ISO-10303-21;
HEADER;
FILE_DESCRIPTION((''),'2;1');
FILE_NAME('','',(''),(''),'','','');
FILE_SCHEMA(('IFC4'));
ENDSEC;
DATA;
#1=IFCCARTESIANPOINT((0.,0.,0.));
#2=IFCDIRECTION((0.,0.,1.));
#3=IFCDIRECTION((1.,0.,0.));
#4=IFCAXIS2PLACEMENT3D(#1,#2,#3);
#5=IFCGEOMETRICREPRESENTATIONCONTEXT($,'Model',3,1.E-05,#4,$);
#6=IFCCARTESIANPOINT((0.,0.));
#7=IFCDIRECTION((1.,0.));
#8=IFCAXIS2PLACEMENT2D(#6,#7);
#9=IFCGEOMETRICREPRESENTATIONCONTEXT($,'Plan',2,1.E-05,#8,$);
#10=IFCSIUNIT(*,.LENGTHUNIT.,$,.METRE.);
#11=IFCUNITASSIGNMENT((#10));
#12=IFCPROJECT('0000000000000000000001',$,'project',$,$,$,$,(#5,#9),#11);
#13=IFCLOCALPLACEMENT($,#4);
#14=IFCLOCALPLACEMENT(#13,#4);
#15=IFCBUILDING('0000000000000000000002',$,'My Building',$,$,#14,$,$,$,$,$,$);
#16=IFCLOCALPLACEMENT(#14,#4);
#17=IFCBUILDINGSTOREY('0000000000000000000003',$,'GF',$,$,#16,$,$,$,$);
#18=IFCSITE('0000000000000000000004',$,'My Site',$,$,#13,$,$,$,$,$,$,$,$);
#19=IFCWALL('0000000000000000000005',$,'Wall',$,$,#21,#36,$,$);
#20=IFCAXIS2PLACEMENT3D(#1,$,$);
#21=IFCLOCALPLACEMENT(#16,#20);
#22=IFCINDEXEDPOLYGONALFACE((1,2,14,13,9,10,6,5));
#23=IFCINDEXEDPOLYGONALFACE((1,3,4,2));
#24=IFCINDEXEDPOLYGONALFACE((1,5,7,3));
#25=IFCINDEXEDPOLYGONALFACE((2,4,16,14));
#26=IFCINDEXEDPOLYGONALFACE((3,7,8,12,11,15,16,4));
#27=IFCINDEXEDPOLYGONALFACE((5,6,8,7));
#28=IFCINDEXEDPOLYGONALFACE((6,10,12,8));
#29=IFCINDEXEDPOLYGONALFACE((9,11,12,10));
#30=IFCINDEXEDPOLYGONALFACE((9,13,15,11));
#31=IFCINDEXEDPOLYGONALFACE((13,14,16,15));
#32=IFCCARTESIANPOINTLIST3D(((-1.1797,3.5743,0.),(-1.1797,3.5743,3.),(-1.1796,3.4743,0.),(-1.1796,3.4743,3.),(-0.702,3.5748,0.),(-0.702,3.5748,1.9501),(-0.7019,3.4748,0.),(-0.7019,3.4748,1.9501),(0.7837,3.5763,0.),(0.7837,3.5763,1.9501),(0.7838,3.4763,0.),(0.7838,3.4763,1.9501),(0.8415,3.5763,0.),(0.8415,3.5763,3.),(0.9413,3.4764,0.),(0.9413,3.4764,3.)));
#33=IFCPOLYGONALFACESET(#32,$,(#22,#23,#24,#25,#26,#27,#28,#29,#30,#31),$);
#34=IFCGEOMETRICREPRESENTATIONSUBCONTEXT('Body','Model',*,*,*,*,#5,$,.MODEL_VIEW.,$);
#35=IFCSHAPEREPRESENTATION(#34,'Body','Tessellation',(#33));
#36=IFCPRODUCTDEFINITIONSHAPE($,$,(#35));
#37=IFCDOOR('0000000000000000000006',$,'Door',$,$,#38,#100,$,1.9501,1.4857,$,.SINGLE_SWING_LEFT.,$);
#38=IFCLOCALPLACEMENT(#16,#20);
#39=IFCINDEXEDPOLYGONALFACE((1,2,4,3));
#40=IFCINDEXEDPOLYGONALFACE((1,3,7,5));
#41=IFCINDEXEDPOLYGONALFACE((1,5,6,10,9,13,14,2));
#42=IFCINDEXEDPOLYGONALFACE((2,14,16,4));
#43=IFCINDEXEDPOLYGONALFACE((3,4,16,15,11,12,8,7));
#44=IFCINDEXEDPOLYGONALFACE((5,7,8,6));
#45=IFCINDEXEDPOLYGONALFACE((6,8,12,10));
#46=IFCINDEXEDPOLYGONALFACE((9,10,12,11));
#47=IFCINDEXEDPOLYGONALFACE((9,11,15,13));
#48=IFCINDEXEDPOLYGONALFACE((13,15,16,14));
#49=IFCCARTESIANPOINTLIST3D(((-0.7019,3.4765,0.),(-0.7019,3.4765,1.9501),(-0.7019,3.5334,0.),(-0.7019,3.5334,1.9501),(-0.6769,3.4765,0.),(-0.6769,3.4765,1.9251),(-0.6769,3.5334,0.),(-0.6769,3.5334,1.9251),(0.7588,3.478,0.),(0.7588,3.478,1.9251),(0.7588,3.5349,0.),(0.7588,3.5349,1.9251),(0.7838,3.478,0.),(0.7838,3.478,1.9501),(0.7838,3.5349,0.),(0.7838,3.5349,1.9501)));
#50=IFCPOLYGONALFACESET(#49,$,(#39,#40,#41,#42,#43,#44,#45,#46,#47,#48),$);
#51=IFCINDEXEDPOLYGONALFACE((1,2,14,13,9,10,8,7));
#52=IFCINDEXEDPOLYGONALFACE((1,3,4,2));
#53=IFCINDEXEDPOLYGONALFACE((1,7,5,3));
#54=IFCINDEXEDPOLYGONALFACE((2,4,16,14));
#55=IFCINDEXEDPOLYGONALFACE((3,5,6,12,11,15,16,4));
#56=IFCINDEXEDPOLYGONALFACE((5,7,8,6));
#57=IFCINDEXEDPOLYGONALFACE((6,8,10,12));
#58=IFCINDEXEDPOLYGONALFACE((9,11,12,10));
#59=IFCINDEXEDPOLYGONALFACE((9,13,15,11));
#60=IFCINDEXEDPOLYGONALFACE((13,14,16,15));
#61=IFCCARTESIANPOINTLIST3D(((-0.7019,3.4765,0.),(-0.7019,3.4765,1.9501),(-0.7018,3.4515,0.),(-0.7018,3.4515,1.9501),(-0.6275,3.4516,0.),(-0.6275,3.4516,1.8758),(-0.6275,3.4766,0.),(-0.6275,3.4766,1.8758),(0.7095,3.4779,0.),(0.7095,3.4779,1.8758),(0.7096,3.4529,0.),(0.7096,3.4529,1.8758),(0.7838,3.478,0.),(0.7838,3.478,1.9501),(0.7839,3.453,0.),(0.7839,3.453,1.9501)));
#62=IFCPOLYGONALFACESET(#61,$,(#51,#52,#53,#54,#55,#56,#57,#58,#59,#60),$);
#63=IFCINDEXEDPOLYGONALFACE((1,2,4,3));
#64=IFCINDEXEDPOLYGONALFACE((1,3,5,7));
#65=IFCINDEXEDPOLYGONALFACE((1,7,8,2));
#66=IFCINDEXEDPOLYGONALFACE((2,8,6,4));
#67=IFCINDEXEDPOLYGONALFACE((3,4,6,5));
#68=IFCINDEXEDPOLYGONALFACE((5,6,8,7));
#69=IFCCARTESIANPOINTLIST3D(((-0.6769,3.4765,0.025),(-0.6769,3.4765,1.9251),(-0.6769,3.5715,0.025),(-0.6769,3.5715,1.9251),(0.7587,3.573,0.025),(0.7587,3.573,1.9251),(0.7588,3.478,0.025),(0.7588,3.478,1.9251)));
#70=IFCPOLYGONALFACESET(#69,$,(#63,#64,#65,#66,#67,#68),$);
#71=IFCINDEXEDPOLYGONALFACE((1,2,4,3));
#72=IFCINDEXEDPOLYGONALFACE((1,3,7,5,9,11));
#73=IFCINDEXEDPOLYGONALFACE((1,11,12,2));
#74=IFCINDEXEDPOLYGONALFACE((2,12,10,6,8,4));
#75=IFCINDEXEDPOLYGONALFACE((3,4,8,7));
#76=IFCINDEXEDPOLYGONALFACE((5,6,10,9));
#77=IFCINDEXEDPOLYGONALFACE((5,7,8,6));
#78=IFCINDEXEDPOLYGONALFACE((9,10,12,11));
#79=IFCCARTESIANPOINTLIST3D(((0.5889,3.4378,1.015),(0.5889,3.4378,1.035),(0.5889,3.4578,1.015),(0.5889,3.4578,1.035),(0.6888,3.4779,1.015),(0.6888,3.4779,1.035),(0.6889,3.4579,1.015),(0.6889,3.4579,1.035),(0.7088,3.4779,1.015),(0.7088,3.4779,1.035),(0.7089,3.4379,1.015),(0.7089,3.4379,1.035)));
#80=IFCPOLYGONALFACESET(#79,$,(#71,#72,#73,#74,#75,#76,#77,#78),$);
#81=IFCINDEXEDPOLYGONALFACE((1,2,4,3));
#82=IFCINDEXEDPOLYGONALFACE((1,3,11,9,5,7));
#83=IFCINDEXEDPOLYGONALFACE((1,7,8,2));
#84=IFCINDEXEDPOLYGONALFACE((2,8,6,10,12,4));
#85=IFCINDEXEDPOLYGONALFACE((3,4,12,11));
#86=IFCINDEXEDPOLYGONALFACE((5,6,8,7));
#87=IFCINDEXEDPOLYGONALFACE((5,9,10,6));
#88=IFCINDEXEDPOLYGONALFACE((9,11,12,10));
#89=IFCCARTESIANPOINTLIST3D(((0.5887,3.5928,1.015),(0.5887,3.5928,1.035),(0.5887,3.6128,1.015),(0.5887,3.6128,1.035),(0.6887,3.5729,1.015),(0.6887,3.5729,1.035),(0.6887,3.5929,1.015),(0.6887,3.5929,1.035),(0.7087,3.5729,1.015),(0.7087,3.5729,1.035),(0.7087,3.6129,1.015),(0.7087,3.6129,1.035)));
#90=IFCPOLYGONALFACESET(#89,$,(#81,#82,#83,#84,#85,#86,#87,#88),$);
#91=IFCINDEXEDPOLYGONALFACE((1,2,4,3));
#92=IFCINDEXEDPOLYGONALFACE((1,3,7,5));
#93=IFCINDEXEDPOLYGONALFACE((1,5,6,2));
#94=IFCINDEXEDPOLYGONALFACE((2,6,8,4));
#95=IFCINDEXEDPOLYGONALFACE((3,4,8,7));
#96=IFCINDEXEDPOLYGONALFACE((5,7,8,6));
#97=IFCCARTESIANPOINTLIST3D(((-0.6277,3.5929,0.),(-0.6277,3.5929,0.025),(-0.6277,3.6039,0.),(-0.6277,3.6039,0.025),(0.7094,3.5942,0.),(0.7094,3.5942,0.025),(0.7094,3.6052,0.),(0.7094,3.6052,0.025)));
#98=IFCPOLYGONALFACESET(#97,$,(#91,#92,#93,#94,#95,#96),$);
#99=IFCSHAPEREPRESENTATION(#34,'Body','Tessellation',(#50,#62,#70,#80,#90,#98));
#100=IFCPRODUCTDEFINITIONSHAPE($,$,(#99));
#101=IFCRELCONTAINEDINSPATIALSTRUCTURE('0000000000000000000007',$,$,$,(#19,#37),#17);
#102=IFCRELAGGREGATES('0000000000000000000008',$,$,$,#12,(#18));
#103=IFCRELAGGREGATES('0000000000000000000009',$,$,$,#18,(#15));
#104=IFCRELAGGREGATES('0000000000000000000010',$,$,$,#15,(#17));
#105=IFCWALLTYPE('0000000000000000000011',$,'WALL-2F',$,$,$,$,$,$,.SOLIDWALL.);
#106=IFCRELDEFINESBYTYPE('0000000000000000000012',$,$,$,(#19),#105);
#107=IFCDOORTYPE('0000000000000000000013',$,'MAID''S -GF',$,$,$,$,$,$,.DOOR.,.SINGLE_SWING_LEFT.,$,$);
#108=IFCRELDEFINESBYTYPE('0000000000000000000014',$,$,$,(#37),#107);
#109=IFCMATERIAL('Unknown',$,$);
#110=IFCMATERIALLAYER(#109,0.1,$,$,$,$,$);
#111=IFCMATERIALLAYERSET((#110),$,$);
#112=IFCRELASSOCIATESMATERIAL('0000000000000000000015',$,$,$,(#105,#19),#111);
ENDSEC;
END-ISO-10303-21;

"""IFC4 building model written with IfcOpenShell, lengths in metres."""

from ifc_helpers import new_model, entity, si_unit, frame, origin_with_axes, origin_2d_with_axis, place, context, subcontext, project, spatial, line, indexed_curve, outline, extrude, shape, source, transform, mapped, material, layer, layer_set, layer_usage, type_object, type_shapes, element, fill, save


model = new_model("IFC4")

# Units and contexts
model_context = context("Model", 3, precision=1e-05, world=origin_with_axes())
plan_context = context("Plan", 2, precision=1e-05, world=origin_2d_with_axis())
body_context_1 = subcontext(model_context, "Body", "Model", "MODEL_VIEW")
body_context_2 = subcontext(plan_context, "Body", "Plan", "PLAN_VIEW")
ifc_project = project(units=[si_unit("LENGTHUNIT", "METRE")], contexts=[model_context, plan_context])

# Site, building, storey
site_placement = place(None, origin_with_axes())
site = spatial("IfcSite", under=ifc_project, at=site_placement, Name="My Site")
building_placement = place(site_placement, origin_with_axes())
building = spatial("IfcBuilding", under=site, at=building_placement, Name="My Building")
storey_placement = place(building_placement, origin_with_axes())
storey = spatial("IfcBuildingStorey", under=building, at=storey_placement, Name="GF")

# Shared definitions
ifc_material_1 = material(Name="Unknown")

# Shared definitions
ifc_layer_1 = layer(ifc_material_1, 0.1)
ifc_layer_set_1 = layer_set([ifc_layer_1])
wall_type_1 = type_object("IfcWallType", Name="WALL-2F", PredefinedType="SOLIDWALL", material=ifc_layer_set_1)

# Wall, opening, door
ifc_layer_usage_1 = layer_usage(ifc_layer_set_1, "AXIS2", "POSITIVE", 0.0)
wall_1_placement = place(storey_placement, frame((0.8415, 3.5763, 0.0), z_axis=(0.0, 0.0, 1.0), x_axis=(-1.0, -0.000997, 0.0)))
wall_1 = element("IfcWall", 1, at=wall_1_placement, inside=storey, type_object=wall_type_1, material=ifc_layer_usage_1, Name="Wall", context=body_context_1, shape_type="SweptSolid", body=[
    extrude(outline(indexed_curve([(0.0, 0.0), (-0.0997, 0.1), (2.0212, 0.1), (2.0212, 0.0)], segments=[line(1, 2, 3, 4, 1)])), origin_with_axes(), (0.0, 0.0, 1.0), 3.0),
])
shared_shape_1 = source(origin_with_axes(), body_context_1, "Body", "SweptSolid", [
    extrude(outline(indexed_curve([(0.0, 0.0), (1.4857, 0.0), (1.4857, 1.9501), (0.0, 1.9501)], segments=[line(1, 2, 3, 4, 1)])), frame((0.0, -0.6, 0.0), z_axis=(0.0, -1.0, 0.0), x_axis=(1.0, 0.0, 0.0)), (0.0, 0.0, -1.0), 1.2),
])
opening_1_placement = place(wall_1_placement, frame((1.5436, 0.19, 0.0), z_axis=(0.0, 0.0, 1.0), x_axis=(-1.0, 0.000001, 0.0)))
opening_1 = element("IfcOpeningElement", 2, at=opening_1_placement, cuts=wall_1, PredefinedType="OPENING", context=body_context_1, shape_type="MappedRepresentation", body=[
    mapped(shared_shape_1, transform((0.0, 0.0, 0.0), x_axis=(1.0, 0.0, 0.0), y_axis=(0.0, 1.0, 0.0), z_axis=(0.0, 0.0, 1.0), scale=1.0)),
])
door_type_1 = type_object("IfcDoorType", Name="MAID'S -GF", OperationType="SINGLE_SWING_LEFT", PredefinedType="DOOR")
shared_shape_2 = source(origin_with_axes(), body_context_1, "Body", "SweptSolid", [
    extrude(outline(indexed_curve([(0.0, 0.0), (0.0, 1.9501), (1.4857, 1.9501), (1.4857, 0.0), (1.4607, 0.0), (1.4607, 1.9251), (0.025, 1.9251), (0.025, 0.0)], segments=[line(1, 2, 3, 4, 5, 6, 7, 8, 1)])), frame((0.0, 0.0093, 0.0), z_axis=(0.0, -1.0, 0.0), x_axis=(1.0, 0.0, 0.0)), (0.0, 0.0, -1.0), 0.0569),
    extrude(outline(indexed_curve([(0.0, 0.0), (0.0, 1.9501), (1.4857, 1.9501), (1.4857, 0.0), (1.4114, 0.0), (1.4114, 1.8758), (0.0743, 1.8758), (0.0743, 0.0)], segments=[line(1, 2, 3, 4, 5, 6, 7, 8, 1)])), frame((0.0, -0.0157, 0.0), z_axis=(0.0, -1.0, 0.0), x_axis=(1.0, 0.0, 0.0)), (0.0, 0.0, -1.0), 0.025),
    extrude(outline(indexed_curve([(0.0, 0.0), (1.4357, 0.0), (1.4357, 0.095), (0.0, 0.095)], segments=[line(1, 2, 3, 4, 1)])), frame((0.025, 0.0093, 0.025), z_axis=(0.0, 0.0, 1.0), x_axis=(1.0, 0.0, 0.0)), (0.0, 0.0, 1.0), 1.9001),
    extrude(outline(indexed_curve([(0.0, 0.0), (0.0, -0.04), (-0.12, -0.04), (-0.12, -0.02), (-0.02, -0.02), (-0.02, 0.0)], segments=[line(1, 2, 3, 4, 5, 6, 1)])), frame((1.4107, 0.0093, 1.015), z_axis=(0.0, 0.0, 1.0), x_axis=(1.0, 0.0, 0.0)), (0.0, 0.0, 1.0), 0.02),
    extrude(outline(indexed_curve([(0.0, 0.0), (0.0, 0.04), (-0.12, 0.04), (-0.12, 0.02), (-0.02, 0.02), (-0.02, 0.0)], segments=[line(1, 2, 3, 4, 5, 6, 1)])), frame((1.4107, 0.1043, 1.015), z_axis=(0.0, 0.0, 1.0), x_axis=(1.0, 0.0, 0.0)), (0.0, 0.0, 1.0), 0.02),
    extrude(outline(indexed_curve([(0.0, 0.0), (1.3371, 0.0), (1.3371, 0.011), (0.0, 0.011)], segments=[line(1, 2, 3, 4, 1)])), frame((0.0743, 0.1256, 0.0), z_axis=(0.0, 0.0, 1.0), x_axis=(1.0, 0.0, 0.0)), (0.0, 0.0, 1.0), 0.025),
])
shared_shape_3 = source(origin_with_axes(), body_context_2, "Body", "Curve2D", [
    entity("IfcIndexedPolyCurve", entity("IfcCartesianPointList2D", [[0.0, -0.0157], [0.0, 0.0662], [0.025, 0.0662], [0.025, 0.0093], [0.0743, 0.0093], [0.0743, -0.0157]]), [entity("IfcLineIndex", [1, 2, 3, 4, 5, 6, 1])]),
    entity("IfcIndexedPolyCurve", entity("IfcCartesianPointList2D", [[1.4857, -0.0157], [1.4857, 0.0662], [1.4607, 0.0662], [1.4607, 0.0093], [1.4114, 0.0093], [1.4114, -0.0157]]), [entity("IfcLineIndex", [1, 2, 3, 4, 5, 6, 1])]),
    entity("IfcTrimmedCurve", entity("IfcEllipse", entity("IfcAxis2Placement2D", entity("IfcCartesianPoint", [0.12, 0.0662]), entity("IfcDirection", [1.0, 0.0])), 1.3407, 1.4357), [entity("IfcCartesianPoint", [1.4607, 0.0662])], [entity("IfcCartesianPoint", [0.12, 1.5019])], True, "CARTESIAN"),
    entity("IfcIndexedPolyCurve", entity("IfcCartesianPointList2D", [[0.025, 0.0662], [0.12, 0.0662], [0.12, 1.5019], [0.025, 1.5019]]), [entity("IfcLineIndex", [1, 2, 3, 4, 1])]),
])
type_shapes(door_type_1, [shared_shape_2, shared_shape_3])
door_1_placement = place(opening_1_placement, frame((0.0001, 0.0824, 0.0), z_axis=(0.0, 0.0, 1.0), x_axis=(1.0, 0.0, 0.0)))
door_1 = element("IfcDoor", 3, at=door_1_placement, inside=storey, type_object=door_type_1, Name="Door", OperationType="SINGLE_SWING_LEFT", OverallHeight=1.9501, OverallWidth=1.4857, shapes=[
    shape(body_context_1, "Body", "MappedRepresentation", [mapped(shared_shape_2, transform((0.0, 0.0, 0.0), x_axis=(1.0, 0.0, 0.0), y_axis=(0.0, 1.0, 0.0), z_axis=(0.0, 0.0, 1.0), scale=1.0))]),
    shape(body_context_2, "Body", "MappedRepresentation", [mapped(shared_shape_3, transform((0.0, 0.0, 0.0), x_axis=(1.0, 0.0, 0.0), y_axis=(0.0, 1.0, 0.0), z_axis=(0.0, 0.0, 1.0), scale=1.0))]),
])
fill(opening_1, door_1)

save(model, "model.ifc")
